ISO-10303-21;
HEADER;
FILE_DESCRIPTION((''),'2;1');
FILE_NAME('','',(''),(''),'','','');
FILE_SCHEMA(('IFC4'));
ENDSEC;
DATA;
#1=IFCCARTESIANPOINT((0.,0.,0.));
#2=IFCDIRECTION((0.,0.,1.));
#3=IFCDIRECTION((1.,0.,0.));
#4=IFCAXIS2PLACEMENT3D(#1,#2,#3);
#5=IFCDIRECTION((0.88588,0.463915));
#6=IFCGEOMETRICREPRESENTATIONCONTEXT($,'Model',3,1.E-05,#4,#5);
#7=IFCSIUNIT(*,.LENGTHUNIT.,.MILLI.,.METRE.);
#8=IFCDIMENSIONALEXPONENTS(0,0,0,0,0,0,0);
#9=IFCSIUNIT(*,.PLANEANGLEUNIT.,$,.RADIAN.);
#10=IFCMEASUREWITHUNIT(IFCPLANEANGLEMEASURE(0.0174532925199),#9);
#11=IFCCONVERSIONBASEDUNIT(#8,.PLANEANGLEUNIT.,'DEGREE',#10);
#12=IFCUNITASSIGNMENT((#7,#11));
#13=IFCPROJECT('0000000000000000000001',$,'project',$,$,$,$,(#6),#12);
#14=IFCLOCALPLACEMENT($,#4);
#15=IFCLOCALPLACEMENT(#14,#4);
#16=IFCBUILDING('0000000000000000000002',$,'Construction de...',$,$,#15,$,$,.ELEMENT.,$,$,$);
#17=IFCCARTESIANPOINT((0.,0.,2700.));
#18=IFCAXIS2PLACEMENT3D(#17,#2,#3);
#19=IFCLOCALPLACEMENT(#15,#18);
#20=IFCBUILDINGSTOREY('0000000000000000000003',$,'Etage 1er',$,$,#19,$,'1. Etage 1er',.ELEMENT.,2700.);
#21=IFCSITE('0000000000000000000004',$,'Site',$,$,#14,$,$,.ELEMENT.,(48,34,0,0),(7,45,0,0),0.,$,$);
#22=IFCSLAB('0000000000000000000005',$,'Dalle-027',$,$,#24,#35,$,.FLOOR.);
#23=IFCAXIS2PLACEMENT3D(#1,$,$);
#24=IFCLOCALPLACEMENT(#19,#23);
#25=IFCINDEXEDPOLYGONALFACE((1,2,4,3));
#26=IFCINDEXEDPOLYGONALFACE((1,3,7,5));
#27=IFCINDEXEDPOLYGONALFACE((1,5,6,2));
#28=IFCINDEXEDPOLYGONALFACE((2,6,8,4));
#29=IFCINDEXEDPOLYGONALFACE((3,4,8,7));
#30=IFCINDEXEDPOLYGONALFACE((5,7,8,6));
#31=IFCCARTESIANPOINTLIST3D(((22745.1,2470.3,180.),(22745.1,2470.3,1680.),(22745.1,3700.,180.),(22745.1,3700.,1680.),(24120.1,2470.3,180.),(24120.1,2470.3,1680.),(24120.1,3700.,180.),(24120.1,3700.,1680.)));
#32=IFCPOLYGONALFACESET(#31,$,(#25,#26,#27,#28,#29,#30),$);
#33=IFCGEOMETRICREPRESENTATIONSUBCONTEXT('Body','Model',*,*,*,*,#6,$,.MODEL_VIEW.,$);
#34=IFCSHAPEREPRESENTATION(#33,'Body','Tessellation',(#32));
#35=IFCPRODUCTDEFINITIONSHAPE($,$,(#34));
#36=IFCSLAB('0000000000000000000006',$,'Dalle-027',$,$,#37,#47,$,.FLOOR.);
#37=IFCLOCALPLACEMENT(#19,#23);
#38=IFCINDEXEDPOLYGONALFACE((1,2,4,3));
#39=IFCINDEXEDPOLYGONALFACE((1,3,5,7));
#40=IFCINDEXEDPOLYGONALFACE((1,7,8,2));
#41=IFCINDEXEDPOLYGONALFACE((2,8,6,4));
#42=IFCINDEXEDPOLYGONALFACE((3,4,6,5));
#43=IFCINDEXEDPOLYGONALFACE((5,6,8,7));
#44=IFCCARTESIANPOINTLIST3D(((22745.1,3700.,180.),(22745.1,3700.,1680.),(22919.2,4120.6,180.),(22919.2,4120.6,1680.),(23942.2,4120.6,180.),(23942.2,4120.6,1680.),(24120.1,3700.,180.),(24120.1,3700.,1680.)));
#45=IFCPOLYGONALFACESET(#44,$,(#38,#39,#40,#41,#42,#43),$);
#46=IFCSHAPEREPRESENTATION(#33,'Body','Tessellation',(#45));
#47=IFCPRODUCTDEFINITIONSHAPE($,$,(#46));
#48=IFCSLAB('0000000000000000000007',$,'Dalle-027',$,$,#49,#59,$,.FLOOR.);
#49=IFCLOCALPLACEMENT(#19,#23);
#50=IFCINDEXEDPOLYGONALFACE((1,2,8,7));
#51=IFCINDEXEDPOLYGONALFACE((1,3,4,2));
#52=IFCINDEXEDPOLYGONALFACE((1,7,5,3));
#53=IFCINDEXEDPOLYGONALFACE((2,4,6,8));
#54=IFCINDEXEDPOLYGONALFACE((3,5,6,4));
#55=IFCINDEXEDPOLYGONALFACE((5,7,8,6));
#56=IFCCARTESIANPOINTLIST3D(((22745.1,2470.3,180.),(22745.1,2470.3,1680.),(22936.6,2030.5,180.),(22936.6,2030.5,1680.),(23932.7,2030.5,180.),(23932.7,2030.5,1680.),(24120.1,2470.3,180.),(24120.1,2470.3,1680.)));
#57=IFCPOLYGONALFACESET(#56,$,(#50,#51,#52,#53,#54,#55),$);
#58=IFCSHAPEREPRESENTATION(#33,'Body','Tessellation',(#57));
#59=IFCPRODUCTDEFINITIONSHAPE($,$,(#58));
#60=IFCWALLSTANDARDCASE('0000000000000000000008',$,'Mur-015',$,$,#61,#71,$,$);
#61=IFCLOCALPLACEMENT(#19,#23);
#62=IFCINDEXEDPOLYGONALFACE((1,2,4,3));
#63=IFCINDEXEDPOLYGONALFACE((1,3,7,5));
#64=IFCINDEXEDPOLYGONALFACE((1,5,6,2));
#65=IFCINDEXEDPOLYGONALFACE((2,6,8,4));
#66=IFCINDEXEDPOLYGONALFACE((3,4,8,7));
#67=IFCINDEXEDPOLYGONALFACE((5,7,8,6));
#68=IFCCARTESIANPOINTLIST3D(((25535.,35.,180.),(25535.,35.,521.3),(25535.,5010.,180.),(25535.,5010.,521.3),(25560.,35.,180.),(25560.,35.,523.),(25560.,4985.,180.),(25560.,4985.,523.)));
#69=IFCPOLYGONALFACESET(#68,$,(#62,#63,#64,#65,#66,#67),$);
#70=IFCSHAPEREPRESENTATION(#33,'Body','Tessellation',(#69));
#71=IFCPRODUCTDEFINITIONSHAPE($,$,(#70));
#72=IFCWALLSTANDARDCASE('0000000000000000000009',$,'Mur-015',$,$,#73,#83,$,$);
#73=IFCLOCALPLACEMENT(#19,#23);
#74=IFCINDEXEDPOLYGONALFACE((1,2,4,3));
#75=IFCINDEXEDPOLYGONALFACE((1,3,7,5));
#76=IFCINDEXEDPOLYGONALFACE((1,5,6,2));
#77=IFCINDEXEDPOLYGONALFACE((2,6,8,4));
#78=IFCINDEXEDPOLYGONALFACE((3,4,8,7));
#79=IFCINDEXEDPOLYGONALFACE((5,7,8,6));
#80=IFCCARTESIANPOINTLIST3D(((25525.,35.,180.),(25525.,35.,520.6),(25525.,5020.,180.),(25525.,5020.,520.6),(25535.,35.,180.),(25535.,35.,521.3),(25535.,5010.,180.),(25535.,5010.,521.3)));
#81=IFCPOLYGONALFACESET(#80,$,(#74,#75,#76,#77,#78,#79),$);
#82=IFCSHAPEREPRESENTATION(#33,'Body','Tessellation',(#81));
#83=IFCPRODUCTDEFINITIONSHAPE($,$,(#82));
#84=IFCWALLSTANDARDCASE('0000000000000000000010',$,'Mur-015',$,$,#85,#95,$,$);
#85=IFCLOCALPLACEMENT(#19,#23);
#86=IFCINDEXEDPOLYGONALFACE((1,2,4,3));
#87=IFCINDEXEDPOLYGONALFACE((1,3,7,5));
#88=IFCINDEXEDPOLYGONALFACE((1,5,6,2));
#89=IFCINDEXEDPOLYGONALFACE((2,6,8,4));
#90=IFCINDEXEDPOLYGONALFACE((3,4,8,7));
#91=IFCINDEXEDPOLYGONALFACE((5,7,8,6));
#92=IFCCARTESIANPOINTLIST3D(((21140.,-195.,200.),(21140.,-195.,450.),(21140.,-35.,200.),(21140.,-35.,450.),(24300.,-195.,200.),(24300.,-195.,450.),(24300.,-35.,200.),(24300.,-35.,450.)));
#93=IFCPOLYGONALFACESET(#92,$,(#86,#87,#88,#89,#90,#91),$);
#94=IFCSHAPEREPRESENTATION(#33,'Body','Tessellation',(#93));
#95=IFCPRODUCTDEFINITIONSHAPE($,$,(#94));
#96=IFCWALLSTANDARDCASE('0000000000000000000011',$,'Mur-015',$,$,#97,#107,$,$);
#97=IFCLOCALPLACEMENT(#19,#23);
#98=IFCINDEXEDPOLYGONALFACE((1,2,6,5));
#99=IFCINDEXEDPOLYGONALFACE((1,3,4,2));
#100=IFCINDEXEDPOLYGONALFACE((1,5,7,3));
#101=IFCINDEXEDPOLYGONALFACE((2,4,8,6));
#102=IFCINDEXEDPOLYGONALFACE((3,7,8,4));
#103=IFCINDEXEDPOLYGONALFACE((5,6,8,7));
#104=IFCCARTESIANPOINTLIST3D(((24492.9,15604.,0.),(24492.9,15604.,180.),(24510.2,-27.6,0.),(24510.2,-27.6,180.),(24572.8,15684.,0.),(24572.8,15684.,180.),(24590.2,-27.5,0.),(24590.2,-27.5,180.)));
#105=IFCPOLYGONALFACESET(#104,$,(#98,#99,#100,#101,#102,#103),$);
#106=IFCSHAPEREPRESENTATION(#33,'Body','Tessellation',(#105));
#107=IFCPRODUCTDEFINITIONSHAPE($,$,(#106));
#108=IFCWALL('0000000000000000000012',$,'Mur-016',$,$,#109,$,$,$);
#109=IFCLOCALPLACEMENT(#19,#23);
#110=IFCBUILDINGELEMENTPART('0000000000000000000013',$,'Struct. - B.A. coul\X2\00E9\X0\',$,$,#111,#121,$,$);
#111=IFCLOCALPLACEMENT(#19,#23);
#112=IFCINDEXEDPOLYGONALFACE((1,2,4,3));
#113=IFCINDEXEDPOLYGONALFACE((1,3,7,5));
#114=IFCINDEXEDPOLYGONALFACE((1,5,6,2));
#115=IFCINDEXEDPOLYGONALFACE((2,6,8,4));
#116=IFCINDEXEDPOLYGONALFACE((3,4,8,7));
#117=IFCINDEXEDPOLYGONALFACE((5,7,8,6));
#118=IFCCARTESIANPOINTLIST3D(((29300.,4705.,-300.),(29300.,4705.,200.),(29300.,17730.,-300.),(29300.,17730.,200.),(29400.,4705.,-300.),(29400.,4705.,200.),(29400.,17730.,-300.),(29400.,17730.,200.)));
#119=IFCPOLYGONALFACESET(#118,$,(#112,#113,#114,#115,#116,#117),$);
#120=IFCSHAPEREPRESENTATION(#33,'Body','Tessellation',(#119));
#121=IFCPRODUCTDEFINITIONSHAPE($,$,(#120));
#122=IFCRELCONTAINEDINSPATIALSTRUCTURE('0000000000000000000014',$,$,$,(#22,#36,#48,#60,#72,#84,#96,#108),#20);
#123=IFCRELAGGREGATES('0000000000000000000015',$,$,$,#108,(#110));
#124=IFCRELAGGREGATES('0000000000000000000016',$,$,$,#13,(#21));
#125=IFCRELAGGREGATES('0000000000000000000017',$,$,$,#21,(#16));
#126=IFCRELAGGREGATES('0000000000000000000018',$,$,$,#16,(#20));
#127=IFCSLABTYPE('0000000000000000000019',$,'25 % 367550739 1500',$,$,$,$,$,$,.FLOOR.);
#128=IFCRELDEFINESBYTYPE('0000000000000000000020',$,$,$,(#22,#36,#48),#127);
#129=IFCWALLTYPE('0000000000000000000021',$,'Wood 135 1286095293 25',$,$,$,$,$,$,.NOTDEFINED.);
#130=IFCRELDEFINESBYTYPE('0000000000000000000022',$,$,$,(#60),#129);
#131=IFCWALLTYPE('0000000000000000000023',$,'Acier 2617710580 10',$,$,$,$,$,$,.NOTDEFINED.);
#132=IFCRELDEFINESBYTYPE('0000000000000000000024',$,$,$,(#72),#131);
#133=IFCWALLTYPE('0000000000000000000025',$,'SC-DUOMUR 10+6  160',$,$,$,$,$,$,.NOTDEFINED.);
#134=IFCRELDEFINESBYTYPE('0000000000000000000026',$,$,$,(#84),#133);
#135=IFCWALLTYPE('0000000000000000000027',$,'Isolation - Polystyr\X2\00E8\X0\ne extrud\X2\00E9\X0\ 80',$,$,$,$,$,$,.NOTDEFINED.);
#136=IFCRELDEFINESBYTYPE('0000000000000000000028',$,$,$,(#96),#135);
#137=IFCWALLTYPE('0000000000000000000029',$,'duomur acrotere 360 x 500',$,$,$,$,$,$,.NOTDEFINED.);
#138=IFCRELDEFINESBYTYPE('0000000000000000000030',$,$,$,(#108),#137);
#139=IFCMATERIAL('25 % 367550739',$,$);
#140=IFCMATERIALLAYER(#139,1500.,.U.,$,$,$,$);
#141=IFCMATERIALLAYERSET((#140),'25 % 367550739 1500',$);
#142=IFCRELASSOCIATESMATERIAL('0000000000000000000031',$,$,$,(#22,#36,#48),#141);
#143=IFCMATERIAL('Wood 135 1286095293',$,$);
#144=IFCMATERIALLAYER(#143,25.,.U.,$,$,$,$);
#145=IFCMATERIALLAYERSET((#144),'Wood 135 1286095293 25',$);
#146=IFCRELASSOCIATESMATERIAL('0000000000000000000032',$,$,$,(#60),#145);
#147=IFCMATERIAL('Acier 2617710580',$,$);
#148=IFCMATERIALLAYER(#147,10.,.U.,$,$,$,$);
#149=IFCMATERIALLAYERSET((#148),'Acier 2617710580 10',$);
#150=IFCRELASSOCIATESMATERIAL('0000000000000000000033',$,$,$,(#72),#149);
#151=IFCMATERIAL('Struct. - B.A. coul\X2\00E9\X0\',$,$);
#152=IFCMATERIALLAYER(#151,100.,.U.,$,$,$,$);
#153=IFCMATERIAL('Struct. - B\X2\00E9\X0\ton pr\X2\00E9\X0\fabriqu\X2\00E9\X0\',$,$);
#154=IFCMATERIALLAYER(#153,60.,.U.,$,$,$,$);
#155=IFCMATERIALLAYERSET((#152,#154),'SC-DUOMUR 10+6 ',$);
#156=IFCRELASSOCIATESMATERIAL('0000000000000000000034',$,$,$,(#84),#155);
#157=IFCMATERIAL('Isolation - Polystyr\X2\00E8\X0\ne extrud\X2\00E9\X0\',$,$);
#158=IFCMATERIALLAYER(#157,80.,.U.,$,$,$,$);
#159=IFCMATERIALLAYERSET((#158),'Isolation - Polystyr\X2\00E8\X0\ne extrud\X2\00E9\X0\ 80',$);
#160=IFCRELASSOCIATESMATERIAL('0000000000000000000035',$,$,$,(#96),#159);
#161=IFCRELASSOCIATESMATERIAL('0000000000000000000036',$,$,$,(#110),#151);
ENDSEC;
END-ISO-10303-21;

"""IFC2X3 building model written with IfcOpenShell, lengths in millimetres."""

from ifc_helpers import new_model, entity, si_unit, converted_unit, direction, frame, origin_with_axes, place, context, subcontext, project, spatial, polyline, outline, extrude, clip, halfspace, material, layer, layer_set, layer_usage, type_object, element, aggregate, save


model = new_model("IFC2X3")

# Units and contexts
model_context = context("Model", 3, precision=1e-05, world=origin_with_axes(), true_north=direction((0.88588, 0.463915)))
body_context = subcontext(model_context, "Body", "Model", "MODEL_VIEW")
ifc_project = project(units=[si_unit("LENGTHUNIT", "METRE", prefix="MILLI"), converted_unit("PLANEANGLEUNIT", "DEGREE", entity("IfcPlaneAngleMeasure", 0.0174532925199), si_unit("PLANEANGLEUNIT", "RADIAN"), dimensions=[0, 0, 0, 0, 0, 0, 0])], contexts=[model_context])

# Site, building, storey
site_placement = place(None, origin_with_axes())
site = spatial("IfcSite", under=ifc_project, at=site_placement, Name="Site", CompositionType="ELEMENT", RefLatitude=(48, 34, 0, 0), RefLongitude=(7, 45, 0, 0), RefElevation=0.0)
building_placement = place(site_placement, origin_with_axes())
building = spatial("IfcBuilding", under=site, at=building_placement, Name="Construction de...", CompositionType="ELEMENT")
storey_placement = place(building_placement, frame((0.0, 0.0, 2700.0), z_axis=(0.0, 0.0, 1.0), x_axis=(1.0, 0.0, 0.0)))
storey = spatial("IfcBuildingStorey", under=building, at=storey_placement, Name="Etage 1er", LongName="1. Etage 1er", CompositionType="ELEMENT", Elevation=2700.0)

# Slabs
ifc_material_1 = material(Name="25 % 367550739")
ifc_layer_1 = layer(ifc_material_1, 1500.0, ventilated="UNKNOWN")
ifc_layer_set_1 = layer_set([ifc_layer_1], Name="25 % 367550739 1500")
ifc_layer_usage_1 = layer_usage(ifc_layer_set_1, "AXIS3", "NEGATIVE", 1500.0)
slab_type_1 = type_object("IfcSlabType", Name="25 % 367550739 1500", PredefinedType="FLOOR")
slab_1_placement = place(storey_placement, frame((24120.1, 3700.0, 1680.0), z_axis=(0.0, 0.0, 1.0), x_axis=(1.0, 0.0, 0.0)))
element("IfcSlab", 1, at=slab_1_placement, inside=storey, type_object=slab_type_1, material=ifc_layer_usage_1, Name="Dalle-027", PredefinedType="FLOOR", context=body_context, shape_type="SweptSolid", body=[
    extrude(outline(polyline([(0.0, 0.0), (-1375.0, 0.0), (-1375.0, -1229.8), (0.0, -1229.8), (0.0, 0.0)])), frame((0.0, 0.0, -1500.0), z_axis=(0.0, 0.0, 1.0), x_axis=(1.0, 0.0, 0.0)), (0.0, 0.0, 1.0), 1500.0),
])
ifc_layer_usage_2 = layer_usage(ifc_layer_set_1, "AXIS3", "NEGATIVE", 1500.0)
slab_2_placement = place(storey_placement, frame((24120.1, 3700.0, 1680.0), z_axis=(0.0, 0.0, 1.0), x_axis=(1.0, 0.0, 0.0)))
element("IfcSlab", 2, at=slab_2_placement, inside=storey, type_object=slab_type_1, material=ifc_layer_usage_2, Name="Dalle-027", PredefinedType="FLOOR", context=body_context, shape_type="SweptSolid", body=[
    extrude(outline(polyline([(0.0, 0.0), (-177.9, 420.6), (-1200.9, 420.6), (-1375.0, 0.0), (0.0, 0.0)])), frame((0.0, 0.0, -1500.0), z_axis=(0.0, 0.0, 1.0), x_axis=(1.0, 0.0, 0.0)), (0.0, 0.0, 1.0), 1500.0),
])
ifc_layer_usage_3 = layer_usage(ifc_layer_set_1, "AXIS3", "NEGATIVE", 1500.0)
slab_3_placement = place(storey_placement, frame((22745.1, 2470.3, 1680.0), z_axis=(0.0, 0.0, 1.0), x_axis=(1.0, 0.0, 0.0)))
element("IfcSlab", 3, at=slab_3_placement, inside=storey, type_object=slab_type_1, material=ifc_layer_usage_3, Name="Dalle-027", PredefinedType="FLOOR", context=body_context, shape_type="SweptSolid", body=[
    extrude(outline(polyline([(0.0, 0.0), (191.5, -439.8), (1187.6, -439.8), (1375.0, 0.0), (0.0, 0.0)])), frame((0.0, 0.0, -1500.0), z_axis=(0.0, 0.0, 1.0), x_axis=(1.0, 0.0, 0.0)), (0.0, 0.0, 1.0), 1500.0),
])

# Walls
ifc_material_2 = material(Name="Wood 135 1286095293")
ifc_layer_2 = layer(ifc_material_2, 25.0, ventilated="UNKNOWN")
ifc_layer_set_2 = layer_set([ifc_layer_2], Name="Wood 135 1286095293 25")
ifc_layer_usage_4 = layer_usage(ifc_layer_set_2, "AXIS2", "NEGATIVE", 12.5)
wall_type_1 = type_object("IfcWallType", Name="Wood 135 1286095293 25", PredefinedType="NOTDEFINED")
wall_1_placement = place(storey_placement, frame((25547.5, 35.0, 180.0), z_axis=(0.0, 0.0, 1.0), x_axis=(0.0, 1.0, 0.0)))
element("IfcWallStandardCase", 4, at=wall_1_placement, inside=storey, type_object=wall_type_1, material=ifc_layer_usage_4, Name="Mur-015", context=body_context, shape_type="Clipping", body=[
    clip(extrude(outline(polyline([(0.0, -12.5), (4950.0, -12.5), (4975.0, 12.5), (0.0, 12.5), (0.0, -12.5)])), origin_with_axes(), (0.0, 0.0, 1.0), 445.0), halfspace(frame((0.0, 23.8, 340.5), z_axis=(0.0, -0.069756, -0.997564), x_axis=(0.0, 0.997564, -0.069756)), True)),
])
ifc_material_3 = material(Name="Acier 2617710580")
ifc_layer_3 = layer(ifc_material_3, 10.0, ventilated="UNKNOWN")
ifc_layer_set_3 = layer_set([ifc_layer_3], Name="Acier 2617710580 10")
ifc_layer_usage_5 = layer_usage(ifc_layer_set_3, "AXIS2", "NEGATIVE", 5.0)
wall_type_2 = type_object("IfcWallType", Name="Acier 2617710580 10", PredefinedType="NOTDEFINED")
wall_2_placement = place(storey_placement, frame((25530.0, 35.0, 180.0), z_axis=(0.0, 0.0, 1.0), x_axis=(0.0, 1.0, 0.0)))
element("IfcWallStandardCase", 5, at=wall_2_placement, inside=storey, type_object=wall_type_2, material=ifc_layer_usage_5, Name="Mur-015", context=body_context, shape_type="Clipping", body=[
    clip(extrude(outline(polyline([(0.0, -5.0), (4975.0, -5.0), (4985.0, 5.0), (0.0, 5.0), (0.0, -5.0)])), origin_with_axes(), (0.0, 0.0, 1.0), 445.0), halfspace(frame((0.0, 23.7, 339.3), z_axis=(0.0, -0.069756, -0.997564), x_axis=(0.0, 0.997564, -0.069756)), True)),
])
ifc_material_4 = material(Name="Struct. - Béton préfabriqué")
ifc_material_5 = material(Name="Struct. - B.A. coulé")
ifc_layer_4 = layer(ifc_material_5, 100.0, ventilated="UNKNOWN")
ifc_layer_5 = layer(ifc_material_4, 60.0, ventilated="UNKNOWN")
ifc_layer_set_4 = layer_set([ifc_layer_4, ifc_layer_5], Name="SC-DUOMUR 10+6 ")
ifc_layer_usage_6 = layer_usage(ifc_layer_set_4, "AXIS2", "NEGATIVE", 0.0)
wall_type_3 = type_object("IfcWallType", Name="SC-DUOMUR 10+6  160", PredefinedType="NOTDEFINED")
wall_3_placement = place(storey_placement, frame((24300.0, -195.0, 200.0), z_axis=(0.0, 0.0, 1.0), x_axis=(-1.0, 0.0, 0.0)))
element("IfcWallStandardCase", 6, at=wall_3_placement, inside=storey, type_object=wall_type_3, material=ifc_layer_usage_6, Name="Mur-015", context=body_context, shape_type="SweptSolid", body=[
    extrude(outline(polyline([(0.0, -160.0), (3160.0, -160.0), (3160.0, 0.0), (0.0, 0.0), (0.0, -160.0)])), origin_with_axes(), (0.0, 0.0, 1.0), 250.0),
])
ifc_material_6 = material(Name="Isolation - Polystyrène extrudé")
ifc_layer_6 = layer(ifc_material_6, 80.0, ventilated="UNKNOWN")
ifc_layer_set_5 = layer_set([ifc_layer_6], Name="Isolation - Polystyrène extrudé 80")
ifc_layer_usage_7 = layer_usage(ifc_layer_set_5, "AXIS2", "NEGATIVE", 40.0)
wall_type_4 = type_object("IfcWallType", Name="Isolation - Polystyrène extrudé 80", PredefinedType="NOTDEFINED")
wall_4_placement = place(storey_placement, frame((24550.2, -27.5, 0.0), z_axis=(0.0, 0.0, 1.0), x_axis=(-0.001105, 0.999999, 0.0)))
element("IfcWallStandardCase", 7, at=wall_4_placement, inside=storey, type_object=wall_type_4, material=ifc_layer_usage_7, Name="Mur-015", context=body_context, shape_type="SweptSolid", body=[
    extrude(outline(polyline([(0.0, -40.0), (15711.5, -40.0), (15631.6, 40.0), (0.0, 40.0), (0.0, -40.0)])), origin_with_axes(), (0.0, 0.0, 1.0), 180.0),
])

# Wall, building element part
wall_type_5 = type_object("IfcWallType", Name="duomur acrotere 360 x 500", PredefinedType="NOTDEFINED")
wall_5_placement = place(storey_placement, frame((29500.0, 4705.0, -300.0), z_axis=(0.0, 0.0, 1.0), x_axis=(0.0, 1.0, 0.0)))
wall_5 = element("IfcWall", 8, at=wall_5_placement, inside=storey, type_object=wall_type_5, Name="Mur-016")
building_element_part_1_placement = place(wall_5_placement, origin_with_axes())
building_element_part_1 = element("IfcBuildingElementPart", 9, at=building_element_part_1_placement, material=ifc_material_5, Name="Struct. - B.A. coulé", context=body_context, shape_type="SweptSolid", body=[
    extrude(outline(polyline([(-300.0, 0.0), (-200.0, 0.0), (-200.0, 500.0), (-300.0, 500.0), (-300.0, 0.0)])), frame((0.0, -100.0, 0.0), z_axis=(-1.0, 0.0, 0.0), x_axis=(0.0, -1.0, 0.0)), (0.0, 0.0, -1.0), 13025.0),
])
aggregate(wall_5, [building_element_part_1])

save(model, "model.ifc")
